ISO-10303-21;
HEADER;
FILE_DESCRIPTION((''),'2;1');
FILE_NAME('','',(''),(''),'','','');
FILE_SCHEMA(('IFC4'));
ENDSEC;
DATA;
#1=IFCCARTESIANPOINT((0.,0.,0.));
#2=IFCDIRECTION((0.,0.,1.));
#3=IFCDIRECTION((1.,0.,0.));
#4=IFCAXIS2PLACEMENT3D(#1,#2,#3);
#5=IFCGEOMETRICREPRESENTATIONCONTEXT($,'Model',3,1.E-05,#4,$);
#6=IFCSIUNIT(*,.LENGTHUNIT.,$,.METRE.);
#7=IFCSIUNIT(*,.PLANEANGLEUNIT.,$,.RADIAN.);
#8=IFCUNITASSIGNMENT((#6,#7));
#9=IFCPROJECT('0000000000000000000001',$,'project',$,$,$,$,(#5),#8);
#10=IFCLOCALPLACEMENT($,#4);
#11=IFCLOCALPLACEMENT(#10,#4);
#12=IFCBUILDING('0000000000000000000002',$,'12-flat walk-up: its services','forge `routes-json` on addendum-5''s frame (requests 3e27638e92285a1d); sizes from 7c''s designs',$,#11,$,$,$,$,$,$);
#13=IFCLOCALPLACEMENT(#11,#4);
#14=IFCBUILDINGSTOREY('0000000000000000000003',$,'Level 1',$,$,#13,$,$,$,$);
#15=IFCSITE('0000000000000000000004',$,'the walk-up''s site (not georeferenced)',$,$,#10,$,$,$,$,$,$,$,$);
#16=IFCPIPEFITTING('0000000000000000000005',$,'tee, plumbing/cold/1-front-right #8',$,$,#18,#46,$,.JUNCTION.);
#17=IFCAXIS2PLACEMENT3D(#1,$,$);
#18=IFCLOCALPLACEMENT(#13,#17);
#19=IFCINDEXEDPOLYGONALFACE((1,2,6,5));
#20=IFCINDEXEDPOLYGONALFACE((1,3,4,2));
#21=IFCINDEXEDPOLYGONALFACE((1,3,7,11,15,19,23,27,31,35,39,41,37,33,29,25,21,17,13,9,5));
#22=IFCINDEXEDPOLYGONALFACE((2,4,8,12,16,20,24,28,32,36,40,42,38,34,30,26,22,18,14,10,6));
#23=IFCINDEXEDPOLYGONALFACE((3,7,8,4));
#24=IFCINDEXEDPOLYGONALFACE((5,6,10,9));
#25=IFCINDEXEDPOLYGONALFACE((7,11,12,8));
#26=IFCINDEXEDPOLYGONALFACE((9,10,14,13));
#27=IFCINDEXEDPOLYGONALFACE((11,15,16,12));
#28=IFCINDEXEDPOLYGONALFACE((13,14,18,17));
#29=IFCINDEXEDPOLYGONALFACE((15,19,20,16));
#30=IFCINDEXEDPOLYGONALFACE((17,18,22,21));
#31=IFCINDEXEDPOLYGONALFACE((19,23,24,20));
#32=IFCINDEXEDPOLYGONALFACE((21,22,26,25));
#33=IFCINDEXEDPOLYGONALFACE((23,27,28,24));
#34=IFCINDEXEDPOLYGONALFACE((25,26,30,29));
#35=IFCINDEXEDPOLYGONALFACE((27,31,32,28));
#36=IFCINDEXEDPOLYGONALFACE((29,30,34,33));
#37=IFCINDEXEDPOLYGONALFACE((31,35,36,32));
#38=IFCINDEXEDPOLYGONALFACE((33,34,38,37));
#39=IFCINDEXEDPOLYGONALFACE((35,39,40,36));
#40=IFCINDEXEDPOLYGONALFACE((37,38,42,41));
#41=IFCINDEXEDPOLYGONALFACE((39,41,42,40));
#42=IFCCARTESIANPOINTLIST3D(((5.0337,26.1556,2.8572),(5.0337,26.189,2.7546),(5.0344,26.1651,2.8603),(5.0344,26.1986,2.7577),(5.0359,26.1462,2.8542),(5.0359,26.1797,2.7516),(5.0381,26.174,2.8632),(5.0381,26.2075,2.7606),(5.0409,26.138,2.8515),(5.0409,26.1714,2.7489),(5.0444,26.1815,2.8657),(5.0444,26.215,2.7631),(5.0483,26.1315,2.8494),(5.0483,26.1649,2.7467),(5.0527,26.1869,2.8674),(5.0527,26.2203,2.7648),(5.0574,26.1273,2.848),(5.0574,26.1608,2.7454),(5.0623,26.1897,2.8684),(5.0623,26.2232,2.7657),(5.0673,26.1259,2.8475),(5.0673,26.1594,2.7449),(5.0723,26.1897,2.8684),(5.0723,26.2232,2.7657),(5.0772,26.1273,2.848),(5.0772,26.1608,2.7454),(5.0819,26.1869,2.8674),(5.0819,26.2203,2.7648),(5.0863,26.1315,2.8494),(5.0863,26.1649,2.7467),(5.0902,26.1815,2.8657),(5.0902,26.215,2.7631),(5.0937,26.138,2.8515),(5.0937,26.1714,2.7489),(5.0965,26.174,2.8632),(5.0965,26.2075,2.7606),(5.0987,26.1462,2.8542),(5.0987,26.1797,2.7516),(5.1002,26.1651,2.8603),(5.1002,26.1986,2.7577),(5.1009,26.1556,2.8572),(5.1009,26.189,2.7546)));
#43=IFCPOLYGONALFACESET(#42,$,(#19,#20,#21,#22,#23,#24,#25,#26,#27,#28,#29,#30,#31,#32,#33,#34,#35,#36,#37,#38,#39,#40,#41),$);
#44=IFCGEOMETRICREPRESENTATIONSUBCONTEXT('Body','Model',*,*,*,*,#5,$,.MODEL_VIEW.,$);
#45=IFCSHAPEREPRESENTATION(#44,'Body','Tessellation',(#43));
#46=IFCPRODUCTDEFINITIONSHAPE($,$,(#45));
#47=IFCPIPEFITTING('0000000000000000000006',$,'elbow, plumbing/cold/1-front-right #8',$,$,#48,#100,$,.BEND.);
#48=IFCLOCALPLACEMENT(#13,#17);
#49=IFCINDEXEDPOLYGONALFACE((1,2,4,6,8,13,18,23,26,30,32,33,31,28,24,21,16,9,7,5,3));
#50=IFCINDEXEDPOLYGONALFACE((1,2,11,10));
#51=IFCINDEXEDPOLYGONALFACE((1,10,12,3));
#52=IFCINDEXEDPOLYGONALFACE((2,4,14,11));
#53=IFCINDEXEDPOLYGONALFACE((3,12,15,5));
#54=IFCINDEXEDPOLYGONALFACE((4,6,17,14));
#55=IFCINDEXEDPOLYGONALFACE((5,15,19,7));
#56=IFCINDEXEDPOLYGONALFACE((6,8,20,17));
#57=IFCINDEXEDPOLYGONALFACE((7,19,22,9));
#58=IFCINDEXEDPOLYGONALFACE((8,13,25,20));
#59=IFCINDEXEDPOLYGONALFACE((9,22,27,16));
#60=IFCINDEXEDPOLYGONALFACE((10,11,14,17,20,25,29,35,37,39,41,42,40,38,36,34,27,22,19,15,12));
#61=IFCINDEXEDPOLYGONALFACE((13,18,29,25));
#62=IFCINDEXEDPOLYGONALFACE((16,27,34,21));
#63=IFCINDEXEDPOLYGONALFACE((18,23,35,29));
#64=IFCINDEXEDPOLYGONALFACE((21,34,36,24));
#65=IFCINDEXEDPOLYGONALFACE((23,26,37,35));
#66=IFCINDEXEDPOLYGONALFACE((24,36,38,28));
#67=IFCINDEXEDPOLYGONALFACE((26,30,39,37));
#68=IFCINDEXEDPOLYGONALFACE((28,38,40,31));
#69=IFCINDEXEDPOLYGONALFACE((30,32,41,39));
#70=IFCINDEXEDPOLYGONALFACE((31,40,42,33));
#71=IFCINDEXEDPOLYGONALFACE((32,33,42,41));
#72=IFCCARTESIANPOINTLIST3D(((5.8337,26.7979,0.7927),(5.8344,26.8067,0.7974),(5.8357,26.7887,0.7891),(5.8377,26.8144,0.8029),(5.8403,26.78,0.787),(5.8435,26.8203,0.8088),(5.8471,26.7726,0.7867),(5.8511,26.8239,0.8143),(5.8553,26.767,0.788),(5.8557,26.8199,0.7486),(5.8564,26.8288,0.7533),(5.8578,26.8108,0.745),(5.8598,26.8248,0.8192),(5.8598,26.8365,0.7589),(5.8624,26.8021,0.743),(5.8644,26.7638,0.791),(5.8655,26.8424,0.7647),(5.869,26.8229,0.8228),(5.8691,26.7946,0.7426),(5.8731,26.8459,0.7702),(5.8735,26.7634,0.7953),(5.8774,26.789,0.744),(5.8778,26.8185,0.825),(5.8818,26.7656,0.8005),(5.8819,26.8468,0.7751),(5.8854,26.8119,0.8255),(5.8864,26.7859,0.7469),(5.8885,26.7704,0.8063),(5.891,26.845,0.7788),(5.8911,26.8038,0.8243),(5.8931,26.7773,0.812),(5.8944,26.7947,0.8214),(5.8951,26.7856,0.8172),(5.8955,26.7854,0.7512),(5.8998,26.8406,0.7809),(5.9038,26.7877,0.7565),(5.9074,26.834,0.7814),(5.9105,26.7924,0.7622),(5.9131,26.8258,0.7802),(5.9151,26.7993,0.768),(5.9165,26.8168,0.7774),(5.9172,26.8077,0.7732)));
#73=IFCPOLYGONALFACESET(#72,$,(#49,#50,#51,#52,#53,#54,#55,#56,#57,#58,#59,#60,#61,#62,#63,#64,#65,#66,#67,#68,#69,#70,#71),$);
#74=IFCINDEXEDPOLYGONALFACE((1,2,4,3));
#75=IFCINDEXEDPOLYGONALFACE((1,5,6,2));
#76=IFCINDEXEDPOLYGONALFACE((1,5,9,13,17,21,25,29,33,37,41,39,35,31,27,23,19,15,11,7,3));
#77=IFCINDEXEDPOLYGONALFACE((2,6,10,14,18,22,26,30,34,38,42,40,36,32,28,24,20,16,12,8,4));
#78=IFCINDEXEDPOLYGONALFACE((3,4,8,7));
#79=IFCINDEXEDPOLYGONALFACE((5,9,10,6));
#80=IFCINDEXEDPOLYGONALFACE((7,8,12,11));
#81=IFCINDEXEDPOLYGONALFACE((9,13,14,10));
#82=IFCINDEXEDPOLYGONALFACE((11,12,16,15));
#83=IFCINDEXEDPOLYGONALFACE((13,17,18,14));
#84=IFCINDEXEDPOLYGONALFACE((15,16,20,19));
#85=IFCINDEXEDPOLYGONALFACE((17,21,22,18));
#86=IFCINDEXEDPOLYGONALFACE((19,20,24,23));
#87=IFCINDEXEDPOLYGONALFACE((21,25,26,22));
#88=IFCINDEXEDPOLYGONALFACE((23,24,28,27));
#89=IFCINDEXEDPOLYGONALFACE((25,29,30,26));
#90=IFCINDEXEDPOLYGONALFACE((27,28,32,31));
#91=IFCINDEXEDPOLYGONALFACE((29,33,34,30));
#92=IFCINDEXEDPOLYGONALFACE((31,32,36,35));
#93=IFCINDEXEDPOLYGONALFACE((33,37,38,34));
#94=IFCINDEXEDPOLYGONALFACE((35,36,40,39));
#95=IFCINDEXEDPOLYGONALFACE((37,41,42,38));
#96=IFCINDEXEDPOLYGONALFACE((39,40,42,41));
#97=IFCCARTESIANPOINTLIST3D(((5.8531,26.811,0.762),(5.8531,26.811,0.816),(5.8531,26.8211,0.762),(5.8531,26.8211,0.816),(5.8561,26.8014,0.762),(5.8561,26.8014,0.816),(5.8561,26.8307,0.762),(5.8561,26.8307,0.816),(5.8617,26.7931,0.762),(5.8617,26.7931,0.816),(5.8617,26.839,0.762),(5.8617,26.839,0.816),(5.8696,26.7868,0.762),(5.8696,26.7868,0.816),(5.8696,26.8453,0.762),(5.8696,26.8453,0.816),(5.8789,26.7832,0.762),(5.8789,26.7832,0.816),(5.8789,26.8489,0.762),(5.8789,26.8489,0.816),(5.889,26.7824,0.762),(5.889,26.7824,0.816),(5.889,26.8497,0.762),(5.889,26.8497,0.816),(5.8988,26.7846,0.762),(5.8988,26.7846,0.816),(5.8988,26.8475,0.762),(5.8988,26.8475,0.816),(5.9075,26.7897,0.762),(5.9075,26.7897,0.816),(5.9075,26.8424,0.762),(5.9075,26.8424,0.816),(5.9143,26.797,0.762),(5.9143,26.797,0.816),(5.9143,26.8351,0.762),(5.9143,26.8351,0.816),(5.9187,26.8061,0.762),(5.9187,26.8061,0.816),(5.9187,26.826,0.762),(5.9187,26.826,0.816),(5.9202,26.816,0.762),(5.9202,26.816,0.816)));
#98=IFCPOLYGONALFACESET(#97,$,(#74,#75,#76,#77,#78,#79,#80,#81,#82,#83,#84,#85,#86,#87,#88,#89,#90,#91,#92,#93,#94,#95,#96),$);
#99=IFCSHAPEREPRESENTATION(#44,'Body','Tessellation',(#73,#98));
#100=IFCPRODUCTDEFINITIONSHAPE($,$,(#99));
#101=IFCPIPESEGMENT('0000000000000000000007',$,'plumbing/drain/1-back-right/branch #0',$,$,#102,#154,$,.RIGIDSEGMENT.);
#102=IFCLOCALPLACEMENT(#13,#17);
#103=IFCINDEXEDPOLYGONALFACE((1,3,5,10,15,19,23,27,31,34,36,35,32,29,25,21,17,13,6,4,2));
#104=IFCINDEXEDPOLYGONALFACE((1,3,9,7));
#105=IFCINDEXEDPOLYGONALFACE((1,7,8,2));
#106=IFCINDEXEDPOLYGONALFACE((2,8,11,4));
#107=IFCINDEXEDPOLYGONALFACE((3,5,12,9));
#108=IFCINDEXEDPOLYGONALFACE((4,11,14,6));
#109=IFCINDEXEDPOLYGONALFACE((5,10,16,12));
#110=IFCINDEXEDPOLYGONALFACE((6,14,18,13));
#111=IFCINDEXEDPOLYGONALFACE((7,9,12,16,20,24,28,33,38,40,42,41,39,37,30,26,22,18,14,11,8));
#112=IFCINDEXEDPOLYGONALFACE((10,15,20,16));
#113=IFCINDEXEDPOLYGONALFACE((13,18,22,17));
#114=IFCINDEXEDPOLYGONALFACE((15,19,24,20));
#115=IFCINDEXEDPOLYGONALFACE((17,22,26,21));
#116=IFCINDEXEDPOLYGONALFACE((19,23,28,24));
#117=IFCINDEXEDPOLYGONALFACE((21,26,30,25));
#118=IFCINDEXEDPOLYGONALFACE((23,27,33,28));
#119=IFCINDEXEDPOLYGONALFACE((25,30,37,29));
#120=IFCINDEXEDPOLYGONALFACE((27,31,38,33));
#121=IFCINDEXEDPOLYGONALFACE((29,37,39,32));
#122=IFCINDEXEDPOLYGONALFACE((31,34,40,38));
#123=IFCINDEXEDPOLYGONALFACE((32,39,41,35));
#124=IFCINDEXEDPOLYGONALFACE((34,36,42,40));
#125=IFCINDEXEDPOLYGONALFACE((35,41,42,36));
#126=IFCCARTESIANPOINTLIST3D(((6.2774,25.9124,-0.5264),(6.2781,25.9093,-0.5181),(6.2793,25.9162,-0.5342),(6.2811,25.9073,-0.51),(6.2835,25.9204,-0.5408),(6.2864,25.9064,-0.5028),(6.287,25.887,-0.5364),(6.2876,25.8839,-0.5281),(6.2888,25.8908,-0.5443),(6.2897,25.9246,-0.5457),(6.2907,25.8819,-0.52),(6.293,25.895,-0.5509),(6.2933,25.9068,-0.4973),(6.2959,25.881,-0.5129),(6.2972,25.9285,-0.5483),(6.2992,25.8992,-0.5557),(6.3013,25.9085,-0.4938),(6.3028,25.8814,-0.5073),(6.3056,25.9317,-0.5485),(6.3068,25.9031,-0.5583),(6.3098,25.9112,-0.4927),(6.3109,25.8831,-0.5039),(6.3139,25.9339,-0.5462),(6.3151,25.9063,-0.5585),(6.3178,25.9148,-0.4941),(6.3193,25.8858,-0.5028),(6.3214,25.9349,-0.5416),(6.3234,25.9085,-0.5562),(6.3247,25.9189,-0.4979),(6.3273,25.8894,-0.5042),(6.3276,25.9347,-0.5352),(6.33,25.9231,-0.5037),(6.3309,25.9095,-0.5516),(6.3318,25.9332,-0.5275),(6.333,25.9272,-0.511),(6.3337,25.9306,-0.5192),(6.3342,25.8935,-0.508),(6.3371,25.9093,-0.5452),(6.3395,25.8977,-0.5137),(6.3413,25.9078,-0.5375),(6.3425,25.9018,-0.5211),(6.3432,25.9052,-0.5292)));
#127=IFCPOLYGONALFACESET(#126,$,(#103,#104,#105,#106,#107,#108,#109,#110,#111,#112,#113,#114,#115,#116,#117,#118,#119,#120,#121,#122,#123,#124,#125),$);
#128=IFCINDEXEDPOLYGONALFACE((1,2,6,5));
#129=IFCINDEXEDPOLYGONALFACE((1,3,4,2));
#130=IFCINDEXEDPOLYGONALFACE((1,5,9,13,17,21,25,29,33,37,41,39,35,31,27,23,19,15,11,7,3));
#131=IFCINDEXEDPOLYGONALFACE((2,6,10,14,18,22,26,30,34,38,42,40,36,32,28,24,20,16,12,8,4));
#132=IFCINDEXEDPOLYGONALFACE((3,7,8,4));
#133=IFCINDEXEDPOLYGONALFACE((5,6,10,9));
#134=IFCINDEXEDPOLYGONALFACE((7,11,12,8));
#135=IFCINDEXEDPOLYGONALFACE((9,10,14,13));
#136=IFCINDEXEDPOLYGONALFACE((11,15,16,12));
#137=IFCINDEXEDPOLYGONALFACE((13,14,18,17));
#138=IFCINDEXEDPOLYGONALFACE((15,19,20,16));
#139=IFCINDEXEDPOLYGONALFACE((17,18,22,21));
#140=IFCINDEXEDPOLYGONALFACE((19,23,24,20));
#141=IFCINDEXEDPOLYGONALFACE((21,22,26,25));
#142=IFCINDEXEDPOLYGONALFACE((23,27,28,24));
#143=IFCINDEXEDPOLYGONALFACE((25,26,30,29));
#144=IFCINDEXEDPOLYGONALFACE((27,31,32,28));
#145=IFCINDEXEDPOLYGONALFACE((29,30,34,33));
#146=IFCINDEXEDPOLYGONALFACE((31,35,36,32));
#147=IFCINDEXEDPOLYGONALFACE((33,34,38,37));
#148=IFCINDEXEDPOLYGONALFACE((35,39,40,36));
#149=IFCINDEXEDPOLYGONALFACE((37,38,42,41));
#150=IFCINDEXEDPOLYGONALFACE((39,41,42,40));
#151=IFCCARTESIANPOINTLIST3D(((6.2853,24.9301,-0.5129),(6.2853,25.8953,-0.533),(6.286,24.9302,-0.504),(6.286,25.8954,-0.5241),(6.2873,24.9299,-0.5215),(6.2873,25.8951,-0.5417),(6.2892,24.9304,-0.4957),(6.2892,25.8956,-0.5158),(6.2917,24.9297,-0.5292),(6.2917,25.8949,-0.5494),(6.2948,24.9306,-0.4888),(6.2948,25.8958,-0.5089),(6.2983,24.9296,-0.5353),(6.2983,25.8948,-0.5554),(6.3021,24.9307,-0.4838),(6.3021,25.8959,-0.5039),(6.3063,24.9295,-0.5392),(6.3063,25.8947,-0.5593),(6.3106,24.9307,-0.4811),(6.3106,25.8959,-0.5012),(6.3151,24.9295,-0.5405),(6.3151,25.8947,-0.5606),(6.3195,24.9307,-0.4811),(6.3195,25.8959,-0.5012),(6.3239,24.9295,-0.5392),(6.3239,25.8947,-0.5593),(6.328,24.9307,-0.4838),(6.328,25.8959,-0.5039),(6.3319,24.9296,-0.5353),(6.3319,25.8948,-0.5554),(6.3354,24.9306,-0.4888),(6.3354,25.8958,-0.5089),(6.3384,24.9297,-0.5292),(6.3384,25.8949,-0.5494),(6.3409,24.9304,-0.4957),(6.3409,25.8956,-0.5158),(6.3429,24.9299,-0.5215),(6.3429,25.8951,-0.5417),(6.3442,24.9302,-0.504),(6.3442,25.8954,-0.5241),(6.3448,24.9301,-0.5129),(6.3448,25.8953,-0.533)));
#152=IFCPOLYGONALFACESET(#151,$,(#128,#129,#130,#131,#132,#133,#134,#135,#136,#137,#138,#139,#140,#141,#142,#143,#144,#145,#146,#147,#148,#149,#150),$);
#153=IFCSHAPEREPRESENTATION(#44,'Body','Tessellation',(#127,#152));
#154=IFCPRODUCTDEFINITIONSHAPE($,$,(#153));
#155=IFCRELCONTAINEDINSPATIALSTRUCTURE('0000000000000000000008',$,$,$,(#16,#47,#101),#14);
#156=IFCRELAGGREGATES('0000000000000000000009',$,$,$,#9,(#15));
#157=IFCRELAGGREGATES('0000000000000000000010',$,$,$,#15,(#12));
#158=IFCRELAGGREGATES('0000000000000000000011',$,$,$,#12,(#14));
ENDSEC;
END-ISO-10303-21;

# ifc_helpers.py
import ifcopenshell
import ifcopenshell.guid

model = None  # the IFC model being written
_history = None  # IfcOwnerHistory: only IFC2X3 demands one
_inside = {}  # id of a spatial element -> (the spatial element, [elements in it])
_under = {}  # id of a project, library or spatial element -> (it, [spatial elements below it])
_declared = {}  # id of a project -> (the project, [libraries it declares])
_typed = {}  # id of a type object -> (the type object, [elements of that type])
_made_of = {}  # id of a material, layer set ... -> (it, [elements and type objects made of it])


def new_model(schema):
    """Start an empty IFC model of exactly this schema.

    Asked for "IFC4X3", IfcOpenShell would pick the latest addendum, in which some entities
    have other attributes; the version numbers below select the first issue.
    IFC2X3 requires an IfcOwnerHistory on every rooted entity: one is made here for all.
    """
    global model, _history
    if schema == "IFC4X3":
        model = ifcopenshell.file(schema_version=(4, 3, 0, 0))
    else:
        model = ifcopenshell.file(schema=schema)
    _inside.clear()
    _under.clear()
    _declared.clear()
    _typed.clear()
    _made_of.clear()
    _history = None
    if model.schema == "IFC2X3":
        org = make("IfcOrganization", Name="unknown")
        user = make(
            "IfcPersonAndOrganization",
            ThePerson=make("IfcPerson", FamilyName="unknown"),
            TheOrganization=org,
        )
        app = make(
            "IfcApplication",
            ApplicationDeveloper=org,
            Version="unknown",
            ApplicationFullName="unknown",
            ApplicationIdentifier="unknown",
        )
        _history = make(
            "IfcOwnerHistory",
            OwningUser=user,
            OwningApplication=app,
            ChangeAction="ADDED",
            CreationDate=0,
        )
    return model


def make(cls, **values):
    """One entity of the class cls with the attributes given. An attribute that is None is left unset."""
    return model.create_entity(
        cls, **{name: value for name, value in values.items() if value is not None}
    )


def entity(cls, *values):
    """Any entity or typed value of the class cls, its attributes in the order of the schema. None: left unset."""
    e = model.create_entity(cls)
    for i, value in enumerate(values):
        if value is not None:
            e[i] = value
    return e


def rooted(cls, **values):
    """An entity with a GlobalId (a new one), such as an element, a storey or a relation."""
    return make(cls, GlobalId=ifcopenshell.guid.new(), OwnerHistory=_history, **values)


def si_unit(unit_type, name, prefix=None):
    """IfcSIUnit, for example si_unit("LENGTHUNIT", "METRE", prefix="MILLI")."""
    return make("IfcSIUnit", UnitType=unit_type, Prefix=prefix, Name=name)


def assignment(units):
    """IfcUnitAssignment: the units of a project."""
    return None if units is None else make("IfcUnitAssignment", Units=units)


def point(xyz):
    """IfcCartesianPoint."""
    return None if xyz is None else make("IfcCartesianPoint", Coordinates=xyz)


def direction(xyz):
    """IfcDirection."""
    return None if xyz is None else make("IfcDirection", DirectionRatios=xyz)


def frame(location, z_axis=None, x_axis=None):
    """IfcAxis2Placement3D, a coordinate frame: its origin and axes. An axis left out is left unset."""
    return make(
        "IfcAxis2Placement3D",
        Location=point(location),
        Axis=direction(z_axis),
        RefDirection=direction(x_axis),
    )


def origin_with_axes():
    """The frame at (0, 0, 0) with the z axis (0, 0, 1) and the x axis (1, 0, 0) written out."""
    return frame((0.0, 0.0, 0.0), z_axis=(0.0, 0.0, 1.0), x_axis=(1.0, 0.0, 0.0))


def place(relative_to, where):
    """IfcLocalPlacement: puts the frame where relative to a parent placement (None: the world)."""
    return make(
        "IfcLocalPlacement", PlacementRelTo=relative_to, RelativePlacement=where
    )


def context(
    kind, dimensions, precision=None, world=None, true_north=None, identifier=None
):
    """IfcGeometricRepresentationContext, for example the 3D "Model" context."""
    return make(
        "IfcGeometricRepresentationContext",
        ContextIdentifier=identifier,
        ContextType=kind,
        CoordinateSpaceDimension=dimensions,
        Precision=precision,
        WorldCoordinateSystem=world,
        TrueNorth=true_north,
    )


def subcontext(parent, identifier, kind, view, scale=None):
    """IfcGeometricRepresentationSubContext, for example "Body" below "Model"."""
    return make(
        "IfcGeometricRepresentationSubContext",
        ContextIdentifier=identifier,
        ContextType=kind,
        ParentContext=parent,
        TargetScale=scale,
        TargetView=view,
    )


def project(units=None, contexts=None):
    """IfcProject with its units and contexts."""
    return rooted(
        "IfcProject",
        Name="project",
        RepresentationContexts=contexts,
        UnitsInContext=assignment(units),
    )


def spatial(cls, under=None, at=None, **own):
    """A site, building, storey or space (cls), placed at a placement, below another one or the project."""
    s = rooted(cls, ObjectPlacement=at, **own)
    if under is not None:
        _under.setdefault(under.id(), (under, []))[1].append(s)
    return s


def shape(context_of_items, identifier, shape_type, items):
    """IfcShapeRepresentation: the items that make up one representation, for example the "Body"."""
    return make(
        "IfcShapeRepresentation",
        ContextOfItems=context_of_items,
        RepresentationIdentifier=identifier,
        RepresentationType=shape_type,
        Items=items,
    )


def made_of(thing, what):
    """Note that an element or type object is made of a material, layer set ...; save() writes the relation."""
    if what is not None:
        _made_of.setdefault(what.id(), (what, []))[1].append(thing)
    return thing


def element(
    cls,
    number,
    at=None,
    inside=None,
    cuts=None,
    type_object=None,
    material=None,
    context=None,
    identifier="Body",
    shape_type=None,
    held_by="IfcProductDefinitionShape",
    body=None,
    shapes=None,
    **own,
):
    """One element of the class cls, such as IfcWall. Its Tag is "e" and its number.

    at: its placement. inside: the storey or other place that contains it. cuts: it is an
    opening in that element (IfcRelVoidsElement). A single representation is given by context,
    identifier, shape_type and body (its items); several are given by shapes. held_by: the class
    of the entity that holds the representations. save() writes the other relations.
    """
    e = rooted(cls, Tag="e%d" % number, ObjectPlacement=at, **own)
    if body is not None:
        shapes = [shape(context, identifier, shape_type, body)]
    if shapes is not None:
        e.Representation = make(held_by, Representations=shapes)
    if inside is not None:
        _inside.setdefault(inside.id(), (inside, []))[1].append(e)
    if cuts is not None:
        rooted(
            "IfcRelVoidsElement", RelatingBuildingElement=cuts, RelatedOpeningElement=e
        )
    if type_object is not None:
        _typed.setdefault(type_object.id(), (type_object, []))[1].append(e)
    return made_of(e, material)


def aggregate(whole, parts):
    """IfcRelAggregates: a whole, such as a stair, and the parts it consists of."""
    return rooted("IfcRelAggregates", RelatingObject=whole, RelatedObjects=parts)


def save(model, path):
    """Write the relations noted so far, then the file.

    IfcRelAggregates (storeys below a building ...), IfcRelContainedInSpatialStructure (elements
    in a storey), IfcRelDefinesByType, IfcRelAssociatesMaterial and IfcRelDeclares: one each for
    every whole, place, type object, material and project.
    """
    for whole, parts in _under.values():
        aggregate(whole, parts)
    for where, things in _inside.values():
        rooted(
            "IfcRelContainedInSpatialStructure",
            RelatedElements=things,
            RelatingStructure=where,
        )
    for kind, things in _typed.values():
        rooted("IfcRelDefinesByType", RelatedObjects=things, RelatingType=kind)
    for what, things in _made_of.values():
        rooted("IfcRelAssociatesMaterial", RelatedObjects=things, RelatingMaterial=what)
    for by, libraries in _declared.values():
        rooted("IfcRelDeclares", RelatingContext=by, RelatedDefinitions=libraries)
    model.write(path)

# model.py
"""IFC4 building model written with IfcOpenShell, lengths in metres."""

from ifc_helpers import new_model, entity, si_unit, frame, origin_with_axes, place, context, subcontext, project, spatial, element, save


model = new_model("IFC4")

# Units and contexts
model_context = context("Model", 3, precision=1e-05, world=origin_with_axes())
body_context = subcontext(model_context, "Body", "Model", "MODEL_VIEW")
ifc_project = project(units=[si_unit("LENGTHUNIT", "METRE"), si_unit("PLANEANGLEUNIT", "RADIAN")], contexts=[model_context])

# Site, building, storey
site_placement = place(None, origin_with_axes())
site = spatial("IfcSite", under=ifc_project, at=site_placement, Name="the walk-up's site (not georeferenced)")
building_placement = place(site_placement, origin_with_axes())
building = spatial("IfcBuilding", under=site, at=building_placement, Name="12-flat walk-up: its services", Description="forge `routes-json` on addendum-5's frame (requests 3e27638e92285a1d); sizes from 7c's designs")
storey_placement = place(building_placement, origin_with_axes())
storey = spatial("IfcBuildingStorey", under=building, at=storey_placement, Name="Level 1")

# Pipe fittings
pipe_fitting_1_placement = place(storey_placement, frame((5.0673, 26.158, 2.858), z_axis=(0.0, 0.0, 1.0), x_axis=(1.0, 0.0, 0.0)))
element("IfcPipeFitting", 1, at=pipe_fitting_1_placement, inside=storey, Name="tee, plumbing/cold/1-front-right #8", PredefinedType="JUNCTION", context=body_context, shape_type="AdvancedSweptSolid", body=[
    entity("IfcSweptDiskSolid", entity("IfcPolyline", [entity("IfcCartesianPoint", [0.0, 0.0, 0.0]), entity("IfcCartesianPoint", [0.0, 0.0335, -0.1026])]), 0.0337),
])
pipe_fitting_2_placement = place(storey_placement, frame((5.8644, 26.794, 0.8061), z_axis=(0.0, 0.0, 1.0), x_axis=(1.0, 0.0, 0.0)))
element("IfcPipeFitting", 2, at=pipe_fitting_2_placement, inside=storey, Name="elbow, plumbing/cold/1-front-right #8", PredefinedType="BEND", context=body_context, shape_type="AdvancedSweptSolid", body=[
    entity("IfcSweptDiskSolid", entity("IfcPolyline", [entity("IfcCartesianPoint", [0.0, 0.0, 0.0]), entity("IfcCartesianPoint", [0.022, 0.022, -0.0441])]), 0.0337),
    entity("IfcSweptDiskSolid", entity("IfcPolyline", [entity("IfcCartesianPoint", [0.022, 0.022, -0.0441]), entity("IfcCartesianPoint", [0.022, 0.022, 0.0099])]), 0.0337),
])

# Pipe segment
pipe_segment_1_placement = place(storey_placement, frame((6.3056, 25.9207, -0.5207), z_axis=(0.0, 0.0, 1.0), x_axis=(1.0, 0.0, 0.0)))
element("IfcPipeSegment", 3, at=pipe_segment_1_placement, inside=storey, Name="plumbing/drain/1-back-right/branch #0", PredefinedType="RIGIDSEGMENT", context=body_context, shape_type="AdvancedSweptSolid", body=[
    entity("IfcSweptDiskSolid", entity("IfcPolyline", [entity("IfcCartesianPoint", [0.0, 0.0, 0.0]), entity("IfcCartesianPoint", [0.0095, -0.0254, -0.0101])]), 0.0298),
    entity("IfcSweptDiskSolid", entity("IfcPolyline", [entity("IfcCartesianPoint", [0.0095, -0.0254, -0.0101]), entity("IfcCartesianPoint", [0.0095, -0.9906, 0.0101])]), 0.0298),
])

save(model, "model.ifc")
